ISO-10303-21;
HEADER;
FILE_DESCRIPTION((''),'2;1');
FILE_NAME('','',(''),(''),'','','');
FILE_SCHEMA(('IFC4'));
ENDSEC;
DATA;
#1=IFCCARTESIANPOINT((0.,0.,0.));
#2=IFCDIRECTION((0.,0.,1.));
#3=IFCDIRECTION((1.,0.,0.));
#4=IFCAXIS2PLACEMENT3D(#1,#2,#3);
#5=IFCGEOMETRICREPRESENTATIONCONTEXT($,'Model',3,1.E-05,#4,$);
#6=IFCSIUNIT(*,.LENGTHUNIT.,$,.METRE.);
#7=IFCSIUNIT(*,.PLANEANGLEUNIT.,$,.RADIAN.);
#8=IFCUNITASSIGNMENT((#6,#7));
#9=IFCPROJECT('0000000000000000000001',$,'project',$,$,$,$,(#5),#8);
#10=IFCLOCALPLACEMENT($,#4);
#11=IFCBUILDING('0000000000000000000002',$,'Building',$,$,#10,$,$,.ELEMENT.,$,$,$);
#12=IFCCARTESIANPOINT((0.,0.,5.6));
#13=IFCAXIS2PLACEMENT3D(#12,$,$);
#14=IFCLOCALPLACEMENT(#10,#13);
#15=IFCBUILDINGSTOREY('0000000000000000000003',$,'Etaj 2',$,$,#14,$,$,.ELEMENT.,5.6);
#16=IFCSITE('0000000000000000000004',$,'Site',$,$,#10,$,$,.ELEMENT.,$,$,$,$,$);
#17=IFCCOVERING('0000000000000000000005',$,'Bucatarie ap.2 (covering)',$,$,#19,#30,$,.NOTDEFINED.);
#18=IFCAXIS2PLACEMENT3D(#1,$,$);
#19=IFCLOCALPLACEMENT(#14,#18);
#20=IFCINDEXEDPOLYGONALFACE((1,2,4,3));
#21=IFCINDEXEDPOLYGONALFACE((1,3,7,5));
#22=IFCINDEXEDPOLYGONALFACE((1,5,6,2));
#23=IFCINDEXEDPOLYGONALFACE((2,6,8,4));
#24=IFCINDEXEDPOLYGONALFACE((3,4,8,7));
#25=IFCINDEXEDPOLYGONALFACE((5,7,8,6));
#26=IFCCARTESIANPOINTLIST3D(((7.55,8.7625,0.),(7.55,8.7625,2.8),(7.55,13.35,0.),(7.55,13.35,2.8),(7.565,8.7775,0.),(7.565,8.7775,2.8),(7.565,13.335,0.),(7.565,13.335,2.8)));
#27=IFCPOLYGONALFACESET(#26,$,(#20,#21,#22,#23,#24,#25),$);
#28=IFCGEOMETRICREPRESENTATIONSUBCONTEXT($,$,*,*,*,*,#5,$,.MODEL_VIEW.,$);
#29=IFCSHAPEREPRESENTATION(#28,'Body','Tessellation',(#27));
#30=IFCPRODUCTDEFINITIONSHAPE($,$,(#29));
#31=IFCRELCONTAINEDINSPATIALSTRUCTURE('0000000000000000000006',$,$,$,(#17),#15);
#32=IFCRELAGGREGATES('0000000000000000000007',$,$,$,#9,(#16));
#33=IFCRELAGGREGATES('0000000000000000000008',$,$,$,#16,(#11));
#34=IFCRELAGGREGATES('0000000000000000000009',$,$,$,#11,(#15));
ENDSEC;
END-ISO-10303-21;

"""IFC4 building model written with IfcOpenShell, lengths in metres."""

from ifc_helpers import new_model, si_unit, frame, origin, origin_with_axes, place, context, subcontext, project, spatial, polyline, outline, extrude, element, save


model = new_model("IFC4")

# Units and contexts
model_context = context("Model", 3, precision=1e-05, world=origin_with_axes())
sub_context = subcontext(model_context, None, None, "MODEL_VIEW")
ifc_project = project(units=[si_unit("LENGTHUNIT", "METRE"), si_unit("PLANEANGLEUNIT", "RADIAN")], contexts=[model_context])

# Site, building, storey
placement = place(None, origin_with_axes())
site = spatial("IfcSite", under=ifc_project, at=placement, Name="Site", CompositionType="ELEMENT")
building = spatial("IfcBuilding", under=site, at=placement, Name="Building", CompositionType="ELEMENT")
storey_placement = place(placement, frame((0.0, 0.0, 5.6)))
storey = spatial("IfcBuildingStorey", under=building, at=storey_placement, Name="Etaj 2", CompositionType="ELEMENT", Elevation=5.6)

# Covering
covering_1_placement = place(storey_placement, origin_with_axes())
element("IfcCovering", 1, at=covering_1_placement, inside=storey, Name="Bucatarie ap.2 (covering)", PredefinedType="NOTDEFINED", context=sub_context, shape_type="SweptSolid", body=[
    extrude(outline(polyline([(7.55, 13.35), (7.55, 8.7625), (7.565, 8.7775), (7.565, 13.335), (7.55, 13.35)])), origin(), (0.0, 0.0, 1.0), 2.8),
])

save(model, "model.ifc")
